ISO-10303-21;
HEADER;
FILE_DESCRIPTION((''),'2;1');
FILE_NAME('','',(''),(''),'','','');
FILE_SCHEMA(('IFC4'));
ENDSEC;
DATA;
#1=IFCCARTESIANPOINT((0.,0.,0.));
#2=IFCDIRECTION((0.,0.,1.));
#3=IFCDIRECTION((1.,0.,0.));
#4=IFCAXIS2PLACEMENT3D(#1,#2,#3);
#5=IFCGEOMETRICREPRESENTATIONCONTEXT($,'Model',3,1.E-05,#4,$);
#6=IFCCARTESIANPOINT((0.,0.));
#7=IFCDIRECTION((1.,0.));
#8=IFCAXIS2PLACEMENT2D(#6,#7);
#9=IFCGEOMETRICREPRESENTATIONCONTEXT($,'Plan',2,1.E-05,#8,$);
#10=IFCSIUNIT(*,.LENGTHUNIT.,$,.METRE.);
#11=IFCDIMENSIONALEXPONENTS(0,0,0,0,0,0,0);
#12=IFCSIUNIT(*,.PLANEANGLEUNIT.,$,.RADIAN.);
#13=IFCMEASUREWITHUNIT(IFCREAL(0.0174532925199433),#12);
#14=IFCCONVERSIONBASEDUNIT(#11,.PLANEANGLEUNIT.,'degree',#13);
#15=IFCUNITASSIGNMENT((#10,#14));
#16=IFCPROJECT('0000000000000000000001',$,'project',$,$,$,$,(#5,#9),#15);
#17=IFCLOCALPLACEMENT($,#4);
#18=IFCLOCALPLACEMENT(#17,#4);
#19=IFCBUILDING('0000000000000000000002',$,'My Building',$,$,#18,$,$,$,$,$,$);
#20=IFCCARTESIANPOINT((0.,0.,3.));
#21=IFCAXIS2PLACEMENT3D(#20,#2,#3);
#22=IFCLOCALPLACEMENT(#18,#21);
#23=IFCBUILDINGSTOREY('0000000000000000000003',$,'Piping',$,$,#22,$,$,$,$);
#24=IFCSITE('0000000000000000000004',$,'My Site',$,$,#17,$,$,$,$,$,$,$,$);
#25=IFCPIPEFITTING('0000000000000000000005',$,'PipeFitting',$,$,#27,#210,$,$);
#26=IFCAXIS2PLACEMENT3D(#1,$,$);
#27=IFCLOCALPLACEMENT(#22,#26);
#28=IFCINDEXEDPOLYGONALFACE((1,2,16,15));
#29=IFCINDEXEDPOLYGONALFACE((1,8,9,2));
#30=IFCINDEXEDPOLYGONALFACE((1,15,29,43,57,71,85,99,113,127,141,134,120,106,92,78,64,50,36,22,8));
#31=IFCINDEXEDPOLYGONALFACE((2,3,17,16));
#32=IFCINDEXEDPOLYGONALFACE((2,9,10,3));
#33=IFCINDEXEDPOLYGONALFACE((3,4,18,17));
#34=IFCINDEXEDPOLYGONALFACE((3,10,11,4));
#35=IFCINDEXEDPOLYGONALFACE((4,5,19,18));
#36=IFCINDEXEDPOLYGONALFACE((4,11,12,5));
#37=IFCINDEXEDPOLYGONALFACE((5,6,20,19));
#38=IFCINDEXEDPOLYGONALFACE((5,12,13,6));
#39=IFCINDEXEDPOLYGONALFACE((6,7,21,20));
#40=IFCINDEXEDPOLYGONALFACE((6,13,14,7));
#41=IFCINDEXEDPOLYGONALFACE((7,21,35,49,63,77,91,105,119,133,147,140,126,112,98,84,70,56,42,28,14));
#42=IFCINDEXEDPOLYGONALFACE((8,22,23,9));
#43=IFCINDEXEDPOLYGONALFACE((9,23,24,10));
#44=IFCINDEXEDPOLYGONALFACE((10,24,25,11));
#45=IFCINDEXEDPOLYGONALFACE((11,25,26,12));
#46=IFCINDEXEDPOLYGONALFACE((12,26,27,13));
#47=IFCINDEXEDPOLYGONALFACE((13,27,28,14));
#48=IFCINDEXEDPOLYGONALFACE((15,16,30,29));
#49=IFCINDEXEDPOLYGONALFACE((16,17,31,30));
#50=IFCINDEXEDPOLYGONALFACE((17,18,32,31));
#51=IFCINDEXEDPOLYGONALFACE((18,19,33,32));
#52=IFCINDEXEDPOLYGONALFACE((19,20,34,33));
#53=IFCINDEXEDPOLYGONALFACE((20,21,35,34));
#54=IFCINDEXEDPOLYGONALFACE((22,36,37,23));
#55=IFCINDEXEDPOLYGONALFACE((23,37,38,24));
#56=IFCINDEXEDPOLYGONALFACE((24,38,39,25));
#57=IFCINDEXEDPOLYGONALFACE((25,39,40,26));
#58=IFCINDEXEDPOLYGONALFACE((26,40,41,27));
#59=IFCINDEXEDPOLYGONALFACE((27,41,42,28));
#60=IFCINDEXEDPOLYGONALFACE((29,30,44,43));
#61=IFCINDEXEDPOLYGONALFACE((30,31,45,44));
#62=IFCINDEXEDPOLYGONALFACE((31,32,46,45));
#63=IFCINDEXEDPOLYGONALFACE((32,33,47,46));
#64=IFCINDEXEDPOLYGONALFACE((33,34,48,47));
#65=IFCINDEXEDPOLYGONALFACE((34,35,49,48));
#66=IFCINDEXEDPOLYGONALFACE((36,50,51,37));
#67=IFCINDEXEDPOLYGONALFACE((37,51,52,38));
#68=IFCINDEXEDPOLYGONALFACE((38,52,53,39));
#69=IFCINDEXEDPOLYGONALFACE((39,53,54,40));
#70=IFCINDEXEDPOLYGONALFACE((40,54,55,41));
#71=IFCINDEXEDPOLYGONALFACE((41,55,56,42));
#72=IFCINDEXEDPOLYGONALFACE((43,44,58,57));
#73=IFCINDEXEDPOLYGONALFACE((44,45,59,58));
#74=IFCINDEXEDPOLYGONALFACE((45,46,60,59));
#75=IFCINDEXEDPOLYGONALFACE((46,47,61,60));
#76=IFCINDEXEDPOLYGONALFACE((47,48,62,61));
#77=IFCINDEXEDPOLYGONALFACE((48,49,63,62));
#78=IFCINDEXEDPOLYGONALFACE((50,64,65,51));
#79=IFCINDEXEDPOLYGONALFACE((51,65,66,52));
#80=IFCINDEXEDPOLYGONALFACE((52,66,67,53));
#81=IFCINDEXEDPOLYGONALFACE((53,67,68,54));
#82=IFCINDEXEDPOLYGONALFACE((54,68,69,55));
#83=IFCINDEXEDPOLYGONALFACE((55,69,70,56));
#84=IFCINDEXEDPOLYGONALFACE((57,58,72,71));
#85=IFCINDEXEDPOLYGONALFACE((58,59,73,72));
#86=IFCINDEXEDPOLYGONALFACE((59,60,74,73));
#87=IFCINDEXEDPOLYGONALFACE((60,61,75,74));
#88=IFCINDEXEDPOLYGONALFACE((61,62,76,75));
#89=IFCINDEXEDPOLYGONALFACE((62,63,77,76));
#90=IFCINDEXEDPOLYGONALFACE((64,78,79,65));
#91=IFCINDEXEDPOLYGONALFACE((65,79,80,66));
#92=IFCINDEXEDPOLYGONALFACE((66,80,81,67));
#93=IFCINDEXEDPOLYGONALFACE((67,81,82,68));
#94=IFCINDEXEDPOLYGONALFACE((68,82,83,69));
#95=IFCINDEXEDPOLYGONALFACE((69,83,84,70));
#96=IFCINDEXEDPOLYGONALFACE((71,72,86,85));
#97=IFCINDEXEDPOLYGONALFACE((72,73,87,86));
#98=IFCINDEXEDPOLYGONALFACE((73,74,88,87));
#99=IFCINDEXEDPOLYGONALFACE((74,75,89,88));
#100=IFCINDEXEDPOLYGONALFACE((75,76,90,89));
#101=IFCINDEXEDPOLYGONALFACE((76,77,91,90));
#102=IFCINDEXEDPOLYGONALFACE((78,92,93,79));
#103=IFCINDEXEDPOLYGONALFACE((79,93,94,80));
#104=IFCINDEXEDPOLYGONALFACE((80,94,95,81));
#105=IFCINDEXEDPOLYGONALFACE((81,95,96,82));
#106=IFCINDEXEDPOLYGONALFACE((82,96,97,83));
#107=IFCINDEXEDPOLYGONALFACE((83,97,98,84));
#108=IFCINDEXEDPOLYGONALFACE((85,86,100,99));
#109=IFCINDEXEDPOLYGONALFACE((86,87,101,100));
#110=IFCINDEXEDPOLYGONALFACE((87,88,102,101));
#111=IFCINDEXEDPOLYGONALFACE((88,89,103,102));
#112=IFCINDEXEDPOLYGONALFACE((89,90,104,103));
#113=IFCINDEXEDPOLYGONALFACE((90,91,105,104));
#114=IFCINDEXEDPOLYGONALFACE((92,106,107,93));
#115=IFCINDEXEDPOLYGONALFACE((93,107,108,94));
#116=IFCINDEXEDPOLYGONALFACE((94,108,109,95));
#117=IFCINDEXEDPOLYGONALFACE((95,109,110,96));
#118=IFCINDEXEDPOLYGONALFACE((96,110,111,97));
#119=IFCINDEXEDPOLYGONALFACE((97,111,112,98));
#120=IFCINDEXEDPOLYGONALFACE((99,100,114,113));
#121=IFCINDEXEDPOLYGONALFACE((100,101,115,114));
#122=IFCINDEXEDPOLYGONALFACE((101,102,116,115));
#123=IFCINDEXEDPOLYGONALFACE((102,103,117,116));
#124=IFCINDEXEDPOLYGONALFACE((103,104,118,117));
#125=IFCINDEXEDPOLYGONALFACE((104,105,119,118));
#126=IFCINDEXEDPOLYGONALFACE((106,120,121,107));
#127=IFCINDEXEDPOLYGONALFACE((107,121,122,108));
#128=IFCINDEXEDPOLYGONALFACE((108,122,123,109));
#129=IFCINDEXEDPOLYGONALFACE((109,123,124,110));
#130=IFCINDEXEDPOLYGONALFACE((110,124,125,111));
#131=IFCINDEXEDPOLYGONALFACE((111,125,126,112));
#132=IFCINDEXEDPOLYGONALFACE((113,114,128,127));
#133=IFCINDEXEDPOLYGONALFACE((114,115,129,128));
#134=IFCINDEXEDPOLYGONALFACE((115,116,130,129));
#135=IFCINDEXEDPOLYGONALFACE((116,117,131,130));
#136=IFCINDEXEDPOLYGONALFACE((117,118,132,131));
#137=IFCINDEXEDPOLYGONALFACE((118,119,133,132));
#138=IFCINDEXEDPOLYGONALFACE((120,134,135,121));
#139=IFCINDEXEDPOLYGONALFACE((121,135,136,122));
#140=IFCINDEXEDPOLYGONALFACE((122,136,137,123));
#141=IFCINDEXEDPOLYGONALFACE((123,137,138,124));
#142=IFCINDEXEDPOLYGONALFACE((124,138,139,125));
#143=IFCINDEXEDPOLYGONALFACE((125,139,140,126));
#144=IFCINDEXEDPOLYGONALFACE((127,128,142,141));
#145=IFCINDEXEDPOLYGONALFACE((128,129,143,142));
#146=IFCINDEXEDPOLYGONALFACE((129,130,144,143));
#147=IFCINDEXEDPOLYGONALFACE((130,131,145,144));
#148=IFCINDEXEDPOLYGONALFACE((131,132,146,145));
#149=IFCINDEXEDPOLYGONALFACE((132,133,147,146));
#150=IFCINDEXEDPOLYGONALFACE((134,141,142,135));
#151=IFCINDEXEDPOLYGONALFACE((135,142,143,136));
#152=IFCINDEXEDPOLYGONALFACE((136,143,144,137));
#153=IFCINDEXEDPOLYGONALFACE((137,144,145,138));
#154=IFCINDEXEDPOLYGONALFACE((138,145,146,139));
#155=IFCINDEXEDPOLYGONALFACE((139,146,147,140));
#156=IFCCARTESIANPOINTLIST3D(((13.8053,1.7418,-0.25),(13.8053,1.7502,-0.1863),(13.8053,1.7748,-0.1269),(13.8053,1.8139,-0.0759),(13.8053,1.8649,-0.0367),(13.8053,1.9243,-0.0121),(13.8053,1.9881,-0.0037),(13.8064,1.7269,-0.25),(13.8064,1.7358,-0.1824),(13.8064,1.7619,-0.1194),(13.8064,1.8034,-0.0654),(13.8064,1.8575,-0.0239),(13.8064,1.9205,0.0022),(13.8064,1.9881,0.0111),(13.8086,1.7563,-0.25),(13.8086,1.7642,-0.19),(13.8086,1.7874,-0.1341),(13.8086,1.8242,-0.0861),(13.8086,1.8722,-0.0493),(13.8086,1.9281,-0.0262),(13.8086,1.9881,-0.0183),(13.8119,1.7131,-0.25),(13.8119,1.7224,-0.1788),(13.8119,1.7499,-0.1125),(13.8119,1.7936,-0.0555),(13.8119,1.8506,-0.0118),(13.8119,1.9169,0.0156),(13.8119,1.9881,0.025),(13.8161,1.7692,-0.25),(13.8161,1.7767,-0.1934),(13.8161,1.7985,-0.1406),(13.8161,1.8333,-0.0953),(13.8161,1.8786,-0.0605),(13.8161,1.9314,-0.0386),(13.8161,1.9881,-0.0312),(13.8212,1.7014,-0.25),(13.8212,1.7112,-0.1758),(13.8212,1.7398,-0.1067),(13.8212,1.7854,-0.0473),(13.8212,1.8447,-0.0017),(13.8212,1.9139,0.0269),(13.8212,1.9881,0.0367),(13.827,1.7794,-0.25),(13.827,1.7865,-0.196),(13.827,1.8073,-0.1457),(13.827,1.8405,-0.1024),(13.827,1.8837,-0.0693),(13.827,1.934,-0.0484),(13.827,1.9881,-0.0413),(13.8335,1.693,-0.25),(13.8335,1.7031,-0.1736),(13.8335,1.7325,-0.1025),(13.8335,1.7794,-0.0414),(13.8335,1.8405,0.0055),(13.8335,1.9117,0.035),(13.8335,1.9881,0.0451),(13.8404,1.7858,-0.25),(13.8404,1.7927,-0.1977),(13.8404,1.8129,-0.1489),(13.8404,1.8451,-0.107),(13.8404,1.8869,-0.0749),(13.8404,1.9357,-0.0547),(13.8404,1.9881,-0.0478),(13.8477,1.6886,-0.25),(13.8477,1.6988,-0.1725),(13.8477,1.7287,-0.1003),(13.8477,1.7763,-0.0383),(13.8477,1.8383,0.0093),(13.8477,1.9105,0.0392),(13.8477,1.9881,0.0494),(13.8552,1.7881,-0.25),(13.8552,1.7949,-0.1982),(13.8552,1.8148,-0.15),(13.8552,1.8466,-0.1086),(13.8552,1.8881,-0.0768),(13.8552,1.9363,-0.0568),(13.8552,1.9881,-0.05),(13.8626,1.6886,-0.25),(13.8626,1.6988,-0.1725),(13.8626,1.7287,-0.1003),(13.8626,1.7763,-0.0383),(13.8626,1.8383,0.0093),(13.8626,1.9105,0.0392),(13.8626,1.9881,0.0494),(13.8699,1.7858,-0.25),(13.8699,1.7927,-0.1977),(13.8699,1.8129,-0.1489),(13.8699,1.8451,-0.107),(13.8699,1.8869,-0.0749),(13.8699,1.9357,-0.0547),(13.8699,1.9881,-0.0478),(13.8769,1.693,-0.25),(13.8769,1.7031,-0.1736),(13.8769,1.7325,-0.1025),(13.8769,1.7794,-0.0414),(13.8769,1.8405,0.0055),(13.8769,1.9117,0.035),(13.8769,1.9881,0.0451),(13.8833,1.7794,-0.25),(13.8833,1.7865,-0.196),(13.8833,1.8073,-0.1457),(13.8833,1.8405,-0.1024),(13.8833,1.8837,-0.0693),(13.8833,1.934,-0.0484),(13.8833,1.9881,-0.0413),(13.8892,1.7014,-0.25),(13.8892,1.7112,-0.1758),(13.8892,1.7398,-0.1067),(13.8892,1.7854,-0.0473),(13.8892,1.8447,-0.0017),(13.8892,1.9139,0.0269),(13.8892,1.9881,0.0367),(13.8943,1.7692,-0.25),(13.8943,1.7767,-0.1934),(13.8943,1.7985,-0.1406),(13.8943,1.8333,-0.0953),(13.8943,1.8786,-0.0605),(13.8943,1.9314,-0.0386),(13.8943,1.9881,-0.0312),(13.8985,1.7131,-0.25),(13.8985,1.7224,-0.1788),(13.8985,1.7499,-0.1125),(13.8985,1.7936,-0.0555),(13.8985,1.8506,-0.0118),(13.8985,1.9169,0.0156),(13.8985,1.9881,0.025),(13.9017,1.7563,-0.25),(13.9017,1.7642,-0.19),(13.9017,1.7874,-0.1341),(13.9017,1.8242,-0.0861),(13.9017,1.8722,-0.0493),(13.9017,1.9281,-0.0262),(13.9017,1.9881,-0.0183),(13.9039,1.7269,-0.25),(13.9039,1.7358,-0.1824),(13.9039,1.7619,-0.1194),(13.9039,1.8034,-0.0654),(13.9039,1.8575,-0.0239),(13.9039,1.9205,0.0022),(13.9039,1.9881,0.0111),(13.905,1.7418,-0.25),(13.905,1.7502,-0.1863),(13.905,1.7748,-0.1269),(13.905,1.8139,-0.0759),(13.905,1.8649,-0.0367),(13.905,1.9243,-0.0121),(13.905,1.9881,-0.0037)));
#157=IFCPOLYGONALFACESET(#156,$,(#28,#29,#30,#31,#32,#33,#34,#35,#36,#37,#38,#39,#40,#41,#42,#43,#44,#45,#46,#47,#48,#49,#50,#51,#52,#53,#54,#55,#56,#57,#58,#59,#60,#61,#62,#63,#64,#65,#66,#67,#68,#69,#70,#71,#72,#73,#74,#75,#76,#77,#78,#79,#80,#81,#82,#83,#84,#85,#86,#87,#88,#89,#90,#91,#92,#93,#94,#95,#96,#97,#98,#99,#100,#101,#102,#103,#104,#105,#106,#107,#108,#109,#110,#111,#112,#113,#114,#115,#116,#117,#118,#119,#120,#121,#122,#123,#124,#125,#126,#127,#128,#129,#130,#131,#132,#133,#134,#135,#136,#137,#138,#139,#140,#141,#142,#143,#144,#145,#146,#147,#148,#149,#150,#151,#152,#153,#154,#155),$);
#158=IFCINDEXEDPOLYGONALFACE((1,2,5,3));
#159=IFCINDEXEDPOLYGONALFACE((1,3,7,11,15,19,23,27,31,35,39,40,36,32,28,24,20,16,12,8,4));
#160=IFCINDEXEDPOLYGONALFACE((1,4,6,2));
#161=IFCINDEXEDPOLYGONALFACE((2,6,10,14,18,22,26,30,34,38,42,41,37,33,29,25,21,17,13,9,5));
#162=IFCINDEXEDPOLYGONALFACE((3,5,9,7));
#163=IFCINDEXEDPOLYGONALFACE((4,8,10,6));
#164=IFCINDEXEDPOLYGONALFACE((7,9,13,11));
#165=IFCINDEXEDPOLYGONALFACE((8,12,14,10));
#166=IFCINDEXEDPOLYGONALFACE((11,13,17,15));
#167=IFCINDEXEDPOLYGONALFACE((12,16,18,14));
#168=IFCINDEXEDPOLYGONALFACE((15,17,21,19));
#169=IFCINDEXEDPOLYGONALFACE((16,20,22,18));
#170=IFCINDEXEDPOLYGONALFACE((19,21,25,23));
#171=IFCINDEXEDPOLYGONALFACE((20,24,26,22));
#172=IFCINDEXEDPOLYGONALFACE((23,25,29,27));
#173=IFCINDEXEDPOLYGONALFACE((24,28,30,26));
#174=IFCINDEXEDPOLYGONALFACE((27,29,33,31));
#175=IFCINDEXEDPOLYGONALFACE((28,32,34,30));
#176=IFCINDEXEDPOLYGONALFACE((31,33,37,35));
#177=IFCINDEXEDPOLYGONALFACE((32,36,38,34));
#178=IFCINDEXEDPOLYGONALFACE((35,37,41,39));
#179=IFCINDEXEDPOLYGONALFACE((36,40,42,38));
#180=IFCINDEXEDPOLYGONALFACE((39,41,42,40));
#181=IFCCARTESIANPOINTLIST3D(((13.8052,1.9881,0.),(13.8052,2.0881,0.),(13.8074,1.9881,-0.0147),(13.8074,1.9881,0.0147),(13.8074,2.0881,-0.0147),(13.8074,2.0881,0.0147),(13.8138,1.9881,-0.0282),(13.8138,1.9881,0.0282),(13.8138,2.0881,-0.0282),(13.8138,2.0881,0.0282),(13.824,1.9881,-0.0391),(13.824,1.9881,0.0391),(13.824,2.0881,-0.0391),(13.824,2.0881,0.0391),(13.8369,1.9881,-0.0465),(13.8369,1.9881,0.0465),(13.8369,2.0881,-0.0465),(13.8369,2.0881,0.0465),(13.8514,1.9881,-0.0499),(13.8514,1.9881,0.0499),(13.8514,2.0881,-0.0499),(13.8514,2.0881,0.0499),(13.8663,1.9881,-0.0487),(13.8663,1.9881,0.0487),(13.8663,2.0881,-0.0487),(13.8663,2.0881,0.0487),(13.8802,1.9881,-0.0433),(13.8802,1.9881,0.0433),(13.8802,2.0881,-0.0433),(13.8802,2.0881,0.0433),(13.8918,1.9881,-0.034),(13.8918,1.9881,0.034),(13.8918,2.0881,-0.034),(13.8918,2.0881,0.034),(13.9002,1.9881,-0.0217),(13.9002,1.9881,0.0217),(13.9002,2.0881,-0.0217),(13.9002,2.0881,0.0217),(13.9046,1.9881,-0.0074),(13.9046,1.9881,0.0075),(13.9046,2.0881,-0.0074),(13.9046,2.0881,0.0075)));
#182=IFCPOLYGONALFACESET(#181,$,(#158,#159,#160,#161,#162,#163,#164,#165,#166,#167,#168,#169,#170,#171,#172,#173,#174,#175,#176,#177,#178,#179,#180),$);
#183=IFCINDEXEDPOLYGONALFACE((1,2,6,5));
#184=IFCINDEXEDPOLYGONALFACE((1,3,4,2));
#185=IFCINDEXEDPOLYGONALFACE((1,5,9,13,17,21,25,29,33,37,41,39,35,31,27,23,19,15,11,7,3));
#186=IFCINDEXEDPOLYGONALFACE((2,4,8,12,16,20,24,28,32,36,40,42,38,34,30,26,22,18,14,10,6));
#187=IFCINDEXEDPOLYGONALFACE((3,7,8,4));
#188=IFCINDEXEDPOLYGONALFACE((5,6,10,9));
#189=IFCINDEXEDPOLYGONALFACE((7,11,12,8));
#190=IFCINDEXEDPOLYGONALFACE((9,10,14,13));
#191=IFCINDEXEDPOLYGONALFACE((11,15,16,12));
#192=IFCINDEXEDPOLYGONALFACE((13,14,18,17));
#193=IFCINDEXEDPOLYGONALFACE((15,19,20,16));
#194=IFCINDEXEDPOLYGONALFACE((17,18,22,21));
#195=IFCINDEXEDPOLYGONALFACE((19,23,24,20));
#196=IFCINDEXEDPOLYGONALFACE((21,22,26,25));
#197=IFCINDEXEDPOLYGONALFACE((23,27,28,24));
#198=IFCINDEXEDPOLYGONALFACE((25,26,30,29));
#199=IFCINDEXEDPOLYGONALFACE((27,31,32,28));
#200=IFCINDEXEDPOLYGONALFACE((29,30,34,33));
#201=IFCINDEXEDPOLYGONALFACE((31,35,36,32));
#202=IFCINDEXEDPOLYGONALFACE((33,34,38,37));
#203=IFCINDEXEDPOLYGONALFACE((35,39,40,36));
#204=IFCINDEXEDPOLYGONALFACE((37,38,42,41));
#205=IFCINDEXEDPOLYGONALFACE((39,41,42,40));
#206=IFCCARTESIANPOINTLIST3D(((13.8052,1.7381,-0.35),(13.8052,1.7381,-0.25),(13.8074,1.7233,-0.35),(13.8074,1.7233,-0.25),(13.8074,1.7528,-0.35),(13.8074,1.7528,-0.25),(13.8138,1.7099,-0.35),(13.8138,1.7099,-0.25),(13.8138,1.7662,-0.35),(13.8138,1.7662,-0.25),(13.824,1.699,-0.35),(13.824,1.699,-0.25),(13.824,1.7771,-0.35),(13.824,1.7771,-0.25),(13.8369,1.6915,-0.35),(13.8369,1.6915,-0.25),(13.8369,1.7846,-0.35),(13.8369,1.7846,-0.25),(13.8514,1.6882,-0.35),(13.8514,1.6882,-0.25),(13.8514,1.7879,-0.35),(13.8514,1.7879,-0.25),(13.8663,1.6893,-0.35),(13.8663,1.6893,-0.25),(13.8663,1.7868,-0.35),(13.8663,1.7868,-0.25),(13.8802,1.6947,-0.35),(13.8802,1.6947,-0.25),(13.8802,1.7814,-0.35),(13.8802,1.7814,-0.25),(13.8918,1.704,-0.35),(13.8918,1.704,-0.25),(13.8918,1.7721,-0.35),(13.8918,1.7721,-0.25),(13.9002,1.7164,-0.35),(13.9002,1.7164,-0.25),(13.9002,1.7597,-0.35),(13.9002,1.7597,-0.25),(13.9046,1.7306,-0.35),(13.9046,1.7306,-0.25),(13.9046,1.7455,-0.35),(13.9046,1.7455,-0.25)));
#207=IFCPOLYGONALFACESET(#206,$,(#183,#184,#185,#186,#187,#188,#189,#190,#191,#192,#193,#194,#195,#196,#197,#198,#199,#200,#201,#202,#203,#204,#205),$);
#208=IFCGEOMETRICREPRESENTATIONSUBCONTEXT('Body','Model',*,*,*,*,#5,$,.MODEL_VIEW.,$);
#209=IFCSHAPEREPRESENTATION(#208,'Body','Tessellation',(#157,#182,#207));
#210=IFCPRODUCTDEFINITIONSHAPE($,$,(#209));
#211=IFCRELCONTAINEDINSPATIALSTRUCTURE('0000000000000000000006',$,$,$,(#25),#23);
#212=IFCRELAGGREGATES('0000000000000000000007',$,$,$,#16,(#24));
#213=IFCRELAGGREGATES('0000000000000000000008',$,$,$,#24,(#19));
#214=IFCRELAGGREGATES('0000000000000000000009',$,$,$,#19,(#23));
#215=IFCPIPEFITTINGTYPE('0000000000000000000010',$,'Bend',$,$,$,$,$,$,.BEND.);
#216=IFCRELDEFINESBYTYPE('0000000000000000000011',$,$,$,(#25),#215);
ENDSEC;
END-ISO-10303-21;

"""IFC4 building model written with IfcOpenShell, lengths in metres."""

from ifc_helpers import new_model, entity, si_unit, converted_unit, frame, origin_with_axes, origin_2d_with_axis, place, context, subcontext, project, spatial, circle, extrude, source, transform, mapped, type_object, type_shapes, element, save


model = new_model("IFC4")

# Units and contexts
model_context = context("Model", 3, precision=1e-05, world=origin_with_axes())
plan_context = context("Plan", 2, precision=1e-05, world=origin_2d_with_axis())
body_context = subcontext(model_context, "Body", "Model", "MODEL_VIEW")
ifc_project = project(units=[si_unit("LENGTHUNIT", "METRE"), converted_unit("PLANEANGLEUNIT", "degree", entity("IfcReal", 0.0174532925199433), si_unit("PLANEANGLEUNIT", "RADIAN"), dimensions=[0, 0, 0, 0, 0, 0, 0])], contexts=[model_context, plan_context])

# Site, building, storey
site_placement = place(None, origin_with_axes())
site = spatial("IfcSite", under=ifc_project, at=site_placement, Name="My Site")
building_placement = place(site_placement, origin_with_axes())
building = spatial("IfcBuilding", under=site, at=building_placement, Name="My Building")
storey_placement = place(building_placement, frame((0.0, 0.0, 3.0), z_axis=(0.0, 0.0, 1.0), x_axis=(1.0, 0.0, 0.0)))
storey = spatial("IfcBuildingStorey", under=building, at=storey_placement, Name="Piping")

# Pipe fitting
pipe_fitting_type = type_object("IfcPipeFittingType", Name="Bend", PredefinedType="BEND")
shared_shape = source(origin_with_axes(), body_context, "Body", "SolidModel", [
    entity("IfcSweptDiskSolid", entity("IfcIndexedPolyCurve", entity("IfcCartesianPointList3D", [[0.0, 0.0, -0.1], [0.0, -0.0732, -0.2768], [0.0, -0.25, -0.35]]), [entity("IfcArcIndex", [1, 2, 3])]), 0.05),
    extrude(circle(Radius=0.05), origin_with_axes(), (0.0, 0.0, -1.0), 0.1),
    extrude(circle(Radius=0.05), frame((0.0, -0.25, -0.35), z_axis=(0.0, -1.0, 0.0), x_axis=(1.0, 0.0, 0.0)), (0.0, 0.0, 1.0), 0.1),
])
type_shapes(pipe_fitting_type, [shared_shape])
for number, where, z_axis, x_axis, name in (
    (1, (13.8552, 2.0881, 0.0), (0.0, 1.0, 0.0), (-1.0, 0.0, 0.0), "PipeFitting"),
):
    element("IfcPipeFitting", number, at=place(storey_placement, frame(where, z_axis=z_axis, x_axis=x_axis)), inside=storey, type_object=pipe_fitting_type, Name=name, context=body_context, shape_type="MappedRepresentation", body=[
        mapped(shared_shape, transform((0.0, 0.0, 0.0), x_axis=(1.0, 0.0, 0.0), y_axis=(0.0, 1.0, 0.0), z_axis=(0.0, 0.0, 1.0), scale=1.0)),
    ])

save(model, "model.ifc")
